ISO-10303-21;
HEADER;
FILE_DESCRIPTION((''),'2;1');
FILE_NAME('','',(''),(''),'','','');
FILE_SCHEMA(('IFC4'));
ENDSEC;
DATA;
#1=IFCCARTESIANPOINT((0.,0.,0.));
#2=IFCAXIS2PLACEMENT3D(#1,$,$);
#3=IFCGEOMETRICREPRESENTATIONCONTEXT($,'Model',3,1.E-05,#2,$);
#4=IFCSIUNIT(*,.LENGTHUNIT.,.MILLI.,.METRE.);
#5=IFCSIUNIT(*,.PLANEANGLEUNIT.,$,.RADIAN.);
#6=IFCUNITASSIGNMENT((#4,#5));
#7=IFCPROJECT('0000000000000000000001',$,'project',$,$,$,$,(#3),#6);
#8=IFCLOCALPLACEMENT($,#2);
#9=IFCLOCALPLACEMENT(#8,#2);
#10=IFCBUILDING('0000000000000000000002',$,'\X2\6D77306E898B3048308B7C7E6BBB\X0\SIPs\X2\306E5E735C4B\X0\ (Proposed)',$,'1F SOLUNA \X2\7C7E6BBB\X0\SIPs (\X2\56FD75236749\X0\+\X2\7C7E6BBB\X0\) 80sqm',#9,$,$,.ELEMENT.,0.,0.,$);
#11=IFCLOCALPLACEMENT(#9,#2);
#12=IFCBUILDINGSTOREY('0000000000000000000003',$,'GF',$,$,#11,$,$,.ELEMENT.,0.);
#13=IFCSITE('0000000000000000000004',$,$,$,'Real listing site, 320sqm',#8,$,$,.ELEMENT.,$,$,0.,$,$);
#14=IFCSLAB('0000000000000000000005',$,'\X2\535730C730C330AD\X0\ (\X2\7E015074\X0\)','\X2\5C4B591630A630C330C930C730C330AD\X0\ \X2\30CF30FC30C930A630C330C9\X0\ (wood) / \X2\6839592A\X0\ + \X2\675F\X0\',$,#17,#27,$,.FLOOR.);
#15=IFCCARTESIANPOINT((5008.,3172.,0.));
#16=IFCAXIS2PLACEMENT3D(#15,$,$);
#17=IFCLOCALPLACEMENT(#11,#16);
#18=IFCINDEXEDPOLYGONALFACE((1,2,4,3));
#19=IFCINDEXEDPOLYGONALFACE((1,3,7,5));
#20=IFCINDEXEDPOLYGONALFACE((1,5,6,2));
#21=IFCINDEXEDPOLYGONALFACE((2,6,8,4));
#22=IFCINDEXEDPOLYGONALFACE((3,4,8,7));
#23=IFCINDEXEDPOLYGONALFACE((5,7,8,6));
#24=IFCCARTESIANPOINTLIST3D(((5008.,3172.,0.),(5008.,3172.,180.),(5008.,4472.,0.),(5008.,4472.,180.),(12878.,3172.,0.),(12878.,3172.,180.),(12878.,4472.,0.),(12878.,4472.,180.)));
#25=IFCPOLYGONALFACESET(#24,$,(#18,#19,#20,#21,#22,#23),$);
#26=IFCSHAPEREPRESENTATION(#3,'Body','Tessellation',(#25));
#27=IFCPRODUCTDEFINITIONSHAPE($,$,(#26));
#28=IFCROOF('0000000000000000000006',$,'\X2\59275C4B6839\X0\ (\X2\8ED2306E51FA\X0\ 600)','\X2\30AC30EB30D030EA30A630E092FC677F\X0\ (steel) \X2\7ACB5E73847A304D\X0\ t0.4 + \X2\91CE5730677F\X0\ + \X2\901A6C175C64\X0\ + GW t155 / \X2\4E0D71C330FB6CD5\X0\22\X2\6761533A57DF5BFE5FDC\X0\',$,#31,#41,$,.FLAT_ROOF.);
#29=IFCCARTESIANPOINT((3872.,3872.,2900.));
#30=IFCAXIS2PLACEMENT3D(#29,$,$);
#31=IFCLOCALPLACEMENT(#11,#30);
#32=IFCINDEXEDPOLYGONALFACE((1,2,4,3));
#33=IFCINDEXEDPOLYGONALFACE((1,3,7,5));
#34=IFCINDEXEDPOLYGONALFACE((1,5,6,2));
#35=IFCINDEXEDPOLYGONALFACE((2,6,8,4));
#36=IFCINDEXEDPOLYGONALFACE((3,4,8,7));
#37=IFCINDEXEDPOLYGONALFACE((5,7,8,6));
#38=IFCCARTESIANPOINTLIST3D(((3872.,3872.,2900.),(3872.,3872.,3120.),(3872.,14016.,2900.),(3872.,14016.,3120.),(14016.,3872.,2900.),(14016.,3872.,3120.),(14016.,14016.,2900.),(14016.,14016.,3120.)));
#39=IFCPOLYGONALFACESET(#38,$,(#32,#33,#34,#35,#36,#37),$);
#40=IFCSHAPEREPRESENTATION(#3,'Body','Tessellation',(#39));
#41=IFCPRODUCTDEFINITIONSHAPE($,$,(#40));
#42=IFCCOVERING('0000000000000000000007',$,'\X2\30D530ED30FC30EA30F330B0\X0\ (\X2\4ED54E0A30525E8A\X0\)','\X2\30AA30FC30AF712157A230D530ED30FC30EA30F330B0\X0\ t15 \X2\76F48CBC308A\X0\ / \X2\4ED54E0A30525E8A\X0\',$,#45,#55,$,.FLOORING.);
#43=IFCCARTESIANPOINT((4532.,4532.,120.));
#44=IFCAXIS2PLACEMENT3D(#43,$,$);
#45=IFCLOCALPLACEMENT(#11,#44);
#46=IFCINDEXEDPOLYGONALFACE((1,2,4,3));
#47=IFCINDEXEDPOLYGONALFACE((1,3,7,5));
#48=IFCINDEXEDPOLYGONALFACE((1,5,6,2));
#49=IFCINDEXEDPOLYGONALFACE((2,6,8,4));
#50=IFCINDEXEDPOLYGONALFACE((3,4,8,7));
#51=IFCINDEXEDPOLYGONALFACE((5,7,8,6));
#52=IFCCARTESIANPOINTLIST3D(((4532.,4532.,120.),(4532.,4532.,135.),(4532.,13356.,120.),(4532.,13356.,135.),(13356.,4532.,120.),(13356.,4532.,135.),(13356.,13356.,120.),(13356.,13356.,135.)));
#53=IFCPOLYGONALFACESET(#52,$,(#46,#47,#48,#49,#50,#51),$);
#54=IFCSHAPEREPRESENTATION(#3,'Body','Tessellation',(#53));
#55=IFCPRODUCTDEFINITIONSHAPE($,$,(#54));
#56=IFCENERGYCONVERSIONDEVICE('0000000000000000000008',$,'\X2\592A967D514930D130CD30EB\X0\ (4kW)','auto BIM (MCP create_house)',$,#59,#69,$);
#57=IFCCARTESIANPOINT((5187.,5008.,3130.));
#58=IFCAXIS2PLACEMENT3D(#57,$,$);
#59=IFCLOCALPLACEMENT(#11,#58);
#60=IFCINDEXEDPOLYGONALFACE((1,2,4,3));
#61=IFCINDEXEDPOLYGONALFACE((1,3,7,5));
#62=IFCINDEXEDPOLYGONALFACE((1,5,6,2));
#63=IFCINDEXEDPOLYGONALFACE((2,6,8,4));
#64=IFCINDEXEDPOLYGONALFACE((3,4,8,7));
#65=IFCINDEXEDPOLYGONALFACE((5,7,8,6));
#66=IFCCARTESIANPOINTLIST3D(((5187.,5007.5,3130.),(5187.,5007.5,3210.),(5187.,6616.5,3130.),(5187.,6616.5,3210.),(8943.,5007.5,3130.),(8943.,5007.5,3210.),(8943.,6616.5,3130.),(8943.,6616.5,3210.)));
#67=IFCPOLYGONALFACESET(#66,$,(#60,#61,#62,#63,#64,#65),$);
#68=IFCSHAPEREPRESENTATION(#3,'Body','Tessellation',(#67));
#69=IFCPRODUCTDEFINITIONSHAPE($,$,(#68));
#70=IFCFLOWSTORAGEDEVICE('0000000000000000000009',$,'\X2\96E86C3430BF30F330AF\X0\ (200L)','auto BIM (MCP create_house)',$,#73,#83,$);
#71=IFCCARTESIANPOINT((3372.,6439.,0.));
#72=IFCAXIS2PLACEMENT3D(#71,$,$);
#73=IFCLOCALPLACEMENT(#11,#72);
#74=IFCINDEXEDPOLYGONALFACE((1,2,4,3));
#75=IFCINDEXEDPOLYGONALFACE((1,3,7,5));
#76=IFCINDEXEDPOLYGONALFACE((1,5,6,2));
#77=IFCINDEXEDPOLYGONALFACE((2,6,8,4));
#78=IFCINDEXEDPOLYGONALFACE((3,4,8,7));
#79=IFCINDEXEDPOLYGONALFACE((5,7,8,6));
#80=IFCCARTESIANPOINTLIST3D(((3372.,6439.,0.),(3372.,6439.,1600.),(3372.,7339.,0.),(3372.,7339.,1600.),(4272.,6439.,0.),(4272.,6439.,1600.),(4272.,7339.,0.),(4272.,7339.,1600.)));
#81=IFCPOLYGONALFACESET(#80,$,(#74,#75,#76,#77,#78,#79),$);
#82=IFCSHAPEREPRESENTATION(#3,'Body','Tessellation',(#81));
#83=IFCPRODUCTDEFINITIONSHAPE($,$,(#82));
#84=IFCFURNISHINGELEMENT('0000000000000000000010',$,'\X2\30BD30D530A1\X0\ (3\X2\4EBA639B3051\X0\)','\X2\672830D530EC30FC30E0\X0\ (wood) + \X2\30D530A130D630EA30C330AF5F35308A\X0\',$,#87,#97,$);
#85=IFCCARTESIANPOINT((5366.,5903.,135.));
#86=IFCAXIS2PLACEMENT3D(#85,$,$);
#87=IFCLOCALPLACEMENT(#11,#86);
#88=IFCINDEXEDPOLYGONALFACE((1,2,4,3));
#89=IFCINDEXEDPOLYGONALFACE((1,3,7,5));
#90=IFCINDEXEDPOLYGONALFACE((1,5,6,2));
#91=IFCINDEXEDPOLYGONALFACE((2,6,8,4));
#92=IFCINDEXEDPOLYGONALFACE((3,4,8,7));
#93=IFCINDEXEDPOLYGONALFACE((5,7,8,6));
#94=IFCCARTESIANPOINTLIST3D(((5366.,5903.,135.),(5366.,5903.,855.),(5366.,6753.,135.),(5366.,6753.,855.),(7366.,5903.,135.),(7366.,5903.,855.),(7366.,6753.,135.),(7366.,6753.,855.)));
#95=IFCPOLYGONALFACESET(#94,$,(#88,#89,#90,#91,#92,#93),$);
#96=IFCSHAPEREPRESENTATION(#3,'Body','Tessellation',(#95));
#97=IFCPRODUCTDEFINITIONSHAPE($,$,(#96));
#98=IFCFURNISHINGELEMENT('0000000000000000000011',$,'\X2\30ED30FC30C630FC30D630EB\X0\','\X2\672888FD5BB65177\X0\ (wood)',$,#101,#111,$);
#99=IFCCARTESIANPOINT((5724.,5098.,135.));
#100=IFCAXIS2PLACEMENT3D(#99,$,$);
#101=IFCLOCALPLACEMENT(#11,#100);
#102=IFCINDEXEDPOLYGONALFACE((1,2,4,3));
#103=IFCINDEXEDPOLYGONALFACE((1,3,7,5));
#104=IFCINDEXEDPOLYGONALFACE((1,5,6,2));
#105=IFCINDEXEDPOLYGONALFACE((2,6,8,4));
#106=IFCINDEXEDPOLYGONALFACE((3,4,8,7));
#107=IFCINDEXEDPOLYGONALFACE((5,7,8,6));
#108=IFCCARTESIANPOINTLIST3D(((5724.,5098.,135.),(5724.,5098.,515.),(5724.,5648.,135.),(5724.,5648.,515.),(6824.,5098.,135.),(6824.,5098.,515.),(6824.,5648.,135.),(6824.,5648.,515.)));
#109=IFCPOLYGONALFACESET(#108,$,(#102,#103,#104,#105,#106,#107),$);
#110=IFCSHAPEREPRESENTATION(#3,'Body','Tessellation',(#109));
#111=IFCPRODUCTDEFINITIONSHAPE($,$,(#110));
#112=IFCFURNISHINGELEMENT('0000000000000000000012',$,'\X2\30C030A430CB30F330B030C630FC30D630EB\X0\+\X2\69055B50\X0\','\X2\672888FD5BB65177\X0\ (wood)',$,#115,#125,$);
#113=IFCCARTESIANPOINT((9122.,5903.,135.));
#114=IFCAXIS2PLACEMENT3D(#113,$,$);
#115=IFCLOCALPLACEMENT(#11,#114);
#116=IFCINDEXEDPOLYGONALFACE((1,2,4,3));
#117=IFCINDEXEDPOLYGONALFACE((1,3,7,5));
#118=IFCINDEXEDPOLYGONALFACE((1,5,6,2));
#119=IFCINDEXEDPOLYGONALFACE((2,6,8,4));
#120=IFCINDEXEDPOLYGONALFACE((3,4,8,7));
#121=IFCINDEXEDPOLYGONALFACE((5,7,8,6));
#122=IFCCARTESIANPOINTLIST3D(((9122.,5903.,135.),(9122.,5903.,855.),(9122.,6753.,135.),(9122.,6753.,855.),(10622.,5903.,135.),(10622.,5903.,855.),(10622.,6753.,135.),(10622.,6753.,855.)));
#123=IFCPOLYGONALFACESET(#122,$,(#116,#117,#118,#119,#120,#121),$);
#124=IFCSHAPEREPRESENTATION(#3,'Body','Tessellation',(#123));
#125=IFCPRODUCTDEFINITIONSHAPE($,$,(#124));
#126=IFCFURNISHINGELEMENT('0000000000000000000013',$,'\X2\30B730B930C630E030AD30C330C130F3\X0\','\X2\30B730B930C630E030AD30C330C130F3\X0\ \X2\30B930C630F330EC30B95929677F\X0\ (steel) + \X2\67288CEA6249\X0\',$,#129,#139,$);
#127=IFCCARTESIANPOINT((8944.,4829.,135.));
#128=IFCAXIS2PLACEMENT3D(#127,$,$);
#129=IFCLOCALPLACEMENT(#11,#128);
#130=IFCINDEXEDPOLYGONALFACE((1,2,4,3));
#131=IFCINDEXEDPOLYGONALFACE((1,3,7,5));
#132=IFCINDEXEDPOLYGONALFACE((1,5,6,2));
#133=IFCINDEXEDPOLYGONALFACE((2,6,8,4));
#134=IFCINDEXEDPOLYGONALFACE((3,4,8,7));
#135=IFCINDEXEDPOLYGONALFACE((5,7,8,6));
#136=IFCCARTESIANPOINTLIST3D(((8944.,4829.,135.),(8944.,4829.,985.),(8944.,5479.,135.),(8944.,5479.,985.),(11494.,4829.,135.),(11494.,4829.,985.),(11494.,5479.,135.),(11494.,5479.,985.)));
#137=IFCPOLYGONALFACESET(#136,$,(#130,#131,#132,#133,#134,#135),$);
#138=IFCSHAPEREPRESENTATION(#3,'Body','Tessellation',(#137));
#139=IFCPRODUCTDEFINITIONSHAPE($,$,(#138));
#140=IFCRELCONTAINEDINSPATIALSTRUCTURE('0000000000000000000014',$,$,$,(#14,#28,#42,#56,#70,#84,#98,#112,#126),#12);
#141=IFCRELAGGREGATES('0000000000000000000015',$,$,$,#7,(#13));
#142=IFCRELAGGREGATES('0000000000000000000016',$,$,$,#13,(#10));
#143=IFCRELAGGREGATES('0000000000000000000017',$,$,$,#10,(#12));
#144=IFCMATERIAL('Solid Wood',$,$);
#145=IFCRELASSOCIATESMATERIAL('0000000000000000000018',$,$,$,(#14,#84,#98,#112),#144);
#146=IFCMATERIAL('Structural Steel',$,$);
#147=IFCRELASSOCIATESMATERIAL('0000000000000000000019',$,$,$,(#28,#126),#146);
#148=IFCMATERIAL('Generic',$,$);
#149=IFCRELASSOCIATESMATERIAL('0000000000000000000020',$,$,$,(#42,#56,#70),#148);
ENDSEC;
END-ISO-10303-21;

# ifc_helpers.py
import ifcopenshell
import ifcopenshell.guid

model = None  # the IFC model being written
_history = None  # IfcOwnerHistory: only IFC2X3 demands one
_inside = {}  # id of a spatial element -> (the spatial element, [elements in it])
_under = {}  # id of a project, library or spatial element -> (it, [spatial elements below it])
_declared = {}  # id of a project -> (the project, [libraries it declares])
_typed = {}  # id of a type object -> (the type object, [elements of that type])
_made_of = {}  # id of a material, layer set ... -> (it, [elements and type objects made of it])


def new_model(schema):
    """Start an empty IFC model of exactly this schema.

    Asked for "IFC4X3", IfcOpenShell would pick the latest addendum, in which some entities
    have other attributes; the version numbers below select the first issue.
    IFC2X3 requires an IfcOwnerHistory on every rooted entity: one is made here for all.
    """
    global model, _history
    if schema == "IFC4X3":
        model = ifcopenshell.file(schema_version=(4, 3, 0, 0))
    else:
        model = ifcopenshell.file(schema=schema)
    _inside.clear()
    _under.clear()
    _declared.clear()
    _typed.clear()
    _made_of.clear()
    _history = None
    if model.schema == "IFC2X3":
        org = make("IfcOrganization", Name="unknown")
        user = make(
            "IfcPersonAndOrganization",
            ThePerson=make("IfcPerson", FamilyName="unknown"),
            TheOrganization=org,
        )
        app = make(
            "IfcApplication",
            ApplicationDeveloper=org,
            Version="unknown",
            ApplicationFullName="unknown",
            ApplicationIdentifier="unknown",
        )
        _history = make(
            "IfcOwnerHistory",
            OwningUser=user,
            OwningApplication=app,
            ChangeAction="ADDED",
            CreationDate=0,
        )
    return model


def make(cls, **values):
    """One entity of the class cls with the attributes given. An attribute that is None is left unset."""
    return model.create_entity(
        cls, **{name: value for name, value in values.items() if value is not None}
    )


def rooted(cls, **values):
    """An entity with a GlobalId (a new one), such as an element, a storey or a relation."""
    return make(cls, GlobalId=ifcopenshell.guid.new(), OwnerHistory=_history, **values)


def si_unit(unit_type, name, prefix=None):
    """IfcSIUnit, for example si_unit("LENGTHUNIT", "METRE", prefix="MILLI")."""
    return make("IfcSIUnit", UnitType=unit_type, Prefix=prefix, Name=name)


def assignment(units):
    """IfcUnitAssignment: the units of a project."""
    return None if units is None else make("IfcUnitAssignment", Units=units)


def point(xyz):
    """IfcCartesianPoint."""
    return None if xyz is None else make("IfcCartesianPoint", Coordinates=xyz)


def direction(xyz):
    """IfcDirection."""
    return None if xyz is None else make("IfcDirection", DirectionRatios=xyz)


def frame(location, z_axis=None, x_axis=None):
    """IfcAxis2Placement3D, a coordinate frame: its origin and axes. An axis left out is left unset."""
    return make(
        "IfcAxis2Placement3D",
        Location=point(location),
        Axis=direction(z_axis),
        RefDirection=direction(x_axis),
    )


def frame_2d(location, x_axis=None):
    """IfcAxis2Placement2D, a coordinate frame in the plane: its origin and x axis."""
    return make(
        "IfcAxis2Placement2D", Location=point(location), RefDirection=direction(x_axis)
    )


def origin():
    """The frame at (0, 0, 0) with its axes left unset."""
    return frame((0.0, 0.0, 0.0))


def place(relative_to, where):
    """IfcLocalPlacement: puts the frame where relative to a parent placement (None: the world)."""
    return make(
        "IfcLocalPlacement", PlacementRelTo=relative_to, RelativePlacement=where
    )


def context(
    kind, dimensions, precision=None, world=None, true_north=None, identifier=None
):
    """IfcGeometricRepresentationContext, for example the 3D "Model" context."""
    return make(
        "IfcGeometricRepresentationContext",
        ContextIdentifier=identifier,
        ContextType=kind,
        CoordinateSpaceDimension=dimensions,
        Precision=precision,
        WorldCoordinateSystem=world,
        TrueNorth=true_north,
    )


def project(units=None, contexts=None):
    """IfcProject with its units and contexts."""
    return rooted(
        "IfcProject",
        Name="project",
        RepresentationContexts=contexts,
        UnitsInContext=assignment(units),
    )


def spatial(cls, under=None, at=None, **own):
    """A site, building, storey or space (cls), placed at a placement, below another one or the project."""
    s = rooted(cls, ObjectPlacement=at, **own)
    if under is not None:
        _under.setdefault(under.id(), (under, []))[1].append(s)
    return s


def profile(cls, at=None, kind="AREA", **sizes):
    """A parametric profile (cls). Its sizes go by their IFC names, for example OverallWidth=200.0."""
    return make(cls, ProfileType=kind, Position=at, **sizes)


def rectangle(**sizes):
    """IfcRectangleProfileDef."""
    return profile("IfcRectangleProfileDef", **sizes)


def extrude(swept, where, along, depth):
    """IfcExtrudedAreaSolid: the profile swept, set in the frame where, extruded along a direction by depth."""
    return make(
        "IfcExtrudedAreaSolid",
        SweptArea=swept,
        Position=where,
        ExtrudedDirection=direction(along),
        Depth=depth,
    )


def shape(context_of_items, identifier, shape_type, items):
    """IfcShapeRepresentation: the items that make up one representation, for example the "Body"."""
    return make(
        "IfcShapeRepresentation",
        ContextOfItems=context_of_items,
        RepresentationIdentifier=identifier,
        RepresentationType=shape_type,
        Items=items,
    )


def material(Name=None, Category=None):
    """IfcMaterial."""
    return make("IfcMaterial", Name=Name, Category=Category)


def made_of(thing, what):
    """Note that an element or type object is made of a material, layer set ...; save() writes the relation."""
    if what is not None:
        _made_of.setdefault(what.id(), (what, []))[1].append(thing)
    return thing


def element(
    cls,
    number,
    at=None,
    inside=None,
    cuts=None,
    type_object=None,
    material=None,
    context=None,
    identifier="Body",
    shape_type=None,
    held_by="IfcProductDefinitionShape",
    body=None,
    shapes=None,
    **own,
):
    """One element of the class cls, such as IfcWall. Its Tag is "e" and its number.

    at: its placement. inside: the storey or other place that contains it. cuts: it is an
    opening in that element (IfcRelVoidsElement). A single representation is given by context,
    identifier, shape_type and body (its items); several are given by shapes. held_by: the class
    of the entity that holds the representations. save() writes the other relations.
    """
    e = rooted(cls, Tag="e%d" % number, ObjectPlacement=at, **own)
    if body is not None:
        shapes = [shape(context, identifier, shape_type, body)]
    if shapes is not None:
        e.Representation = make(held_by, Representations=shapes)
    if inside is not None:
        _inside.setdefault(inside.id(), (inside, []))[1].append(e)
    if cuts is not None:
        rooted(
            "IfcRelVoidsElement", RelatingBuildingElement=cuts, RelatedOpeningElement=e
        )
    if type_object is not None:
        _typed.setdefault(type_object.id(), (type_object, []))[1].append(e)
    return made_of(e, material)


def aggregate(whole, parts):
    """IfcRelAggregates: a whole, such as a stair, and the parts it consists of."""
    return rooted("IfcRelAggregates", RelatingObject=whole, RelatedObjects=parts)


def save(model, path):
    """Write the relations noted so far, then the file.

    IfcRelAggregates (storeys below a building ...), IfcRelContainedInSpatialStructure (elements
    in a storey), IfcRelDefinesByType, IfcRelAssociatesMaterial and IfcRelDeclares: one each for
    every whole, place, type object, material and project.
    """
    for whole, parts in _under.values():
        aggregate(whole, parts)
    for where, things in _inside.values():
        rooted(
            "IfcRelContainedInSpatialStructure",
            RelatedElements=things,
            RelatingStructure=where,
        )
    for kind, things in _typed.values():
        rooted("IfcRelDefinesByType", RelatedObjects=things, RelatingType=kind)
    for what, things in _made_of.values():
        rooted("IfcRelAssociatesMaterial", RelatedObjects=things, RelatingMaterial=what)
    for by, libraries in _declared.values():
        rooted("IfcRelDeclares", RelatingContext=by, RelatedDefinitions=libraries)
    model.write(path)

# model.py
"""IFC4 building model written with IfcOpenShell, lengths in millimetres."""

from ifc_helpers import new_model, si_unit, frame, frame_2d, origin, place, context, project, spatial, rectangle, extrude, material, element, save


model = new_model("IFC4")

# Units and contexts
model_context = context("Model", 3, precision=1e-05, world=origin())
ifc_project = project(units=[si_unit("LENGTHUNIT", "METRE", prefix="MILLI"), si_unit("PLANEANGLEUNIT", "RADIAN")], contexts=[model_context])

# Site, building, storey
site_placement = place(None, origin())
site = spatial("IfcSite", under=ifc_project, at=site_placement, ObjectType="Real listing site, 320sqm", CompositionType="ELEMENT", RefElevation=0.0)
building_placement = place(site_placement, origin())
building = spatial("IfcBuilding", under=site, at=building_placement, Name="海の見える籾殻SIPsの平屋 (Proposed)", ObjectType="1F SOLUNA 籾殻SIPs (国産杉+籾殻) 80sqm", CompositionType="ELEMENT", ElevationOfRefHeight=0.0, ElevationOfTerrain=0.0)
storey_placement = place(building_placement, origin())
storey = spatial("IfcBuildingStorey", under=building, at=storey_placement, Name="GF", CompositionType="ELEMENT", Elevation=0.0)

# Slab
ifc_material_1 = material(Name="Solid Wood")
slab_1_placement = place(storey_placement, frame((5008.0, 3172.0, 0.0)))
element("IfcSlab", 1, at=slab_1_placement, inside=storey, material=ifc_material_1, Name="南デッキ (縁側)", Description="屋外ウッドデッキ ハードウッド (wood) / 根太 + 束", PredefinedType="FLOOR", context=model_context, shape_type="SweptSolid", body=[
    extrude(rectangle(XDim=7870.0, YDim=1300.0, at=frame_2d((3935.0, 650.0))), frame((5008.0, 3172.0, 0.0)), (0.0, 0.0, 1.0), 180.0),
])

# Roof
ifc_material_2 = material(Name="Structural Steel")
roof_placement = place(storey_placement, frame((3872.0, 3872.0, 2900.0)))
element("IfcRoof", 2, at=roof_placement, inside=storey, material=ifc_material_2, Name="大屋根 (軒の出 600)", Description="ガルバリウム鋼板 (steel) 立平葺き t0.4 + 野地板 + 通気層 + GW t155 / 不燃・法22条区域対応", PredefinedType="FLAT_ROOF", context=model_context, shape_type="SweptSolid", body=[
    extrude(rectangle(XDim=10144.0, YDim=10144.0, at=frame_2d((5072.0, 5072.0))), frame((3872.0, 3872.0, 2900.0)), (0.0, 0.0, 1.0), 220.0),
])

# Covering
ifc_material_3 = material(Name="Generic")
covering_placement = place(storey_placement, frame((4532.0, 4532.0, 120.0)))
element("IfcCovering", 3, at=covering_placement, inside=storey, material=ifc_material_3, Name="フローリング (仕上げ床)", Description="オーク無垢フローリング t15 直貼り / 仕上げ床", PredefinedType="FLOORING", context=model_context, shape_type="SweptSolid", body=[
    extrude(rectangle(XDim=8824.0, YDim=8824.0, at=frame_2d((4412.0, 4412.0))), frame((4532.0, 4532.0, 120.0)), (0.0, 0.0, 1.0), 15.0),
])

# Energy conversion device
energy_conversion_device_placement = place(storey_placement, frame((5187.0, 5008.0, 3130.0)))
element("IfcEnergyConversionDevice", 4, at=energy_conversion_device_placement, inside=storey, material=ifc_material_3, Name="太陽光パネル (4kW)", Description="auto BIM (MCP create_house)", context=model_context, shape_type="SweptSolid", body=[
    extrude(rectangle(XDim=3756.0, YDim=1609.0, at=frame_2d((1878.0, 804.0))), frame((5187.0, 5008.0, 3130.0)), (0.0, 0.0, 1.0), 80.0),
])

# Flow storage device
flow_storage_device_placement = place(storey_placement, frame((3372.0, 6439.0, 0.0)))
element("IfcFlowStorageDevice", 5, at=flow_storage_device_placement, inside=storey, material=ifc_material_3, Name="雨水タンク (200L)", Description="auto BIM (MCP create_house)", context=model_context, shape_type="SweptSolid", body=[
    extrude(rectangle(XDim=900.0, YDim=900.0, at=frame_2d((450.0, 450.0))), frame((3372.0, 6439.0, 0.0)), (0.0, 0.0, 1.0), 1600.0),
])

# Furnishing elements
furnishing_1_placement = place(storey_placement, frame((5366.0, 5903.0, 135.0)))
element("IfcFurnishingElement", 6, at=furnishing_1_placement, inside=storey, material=ifc_material_1, Name="ソファ (3人掛け)", Description="木フレーム (wood) + ファブリック張り", context=model_context, shape_type="SweptSolid", body=[
    extrude(rectangle(XDim=2000.0, YDim=850.0, at=frame_2d((1000.0, 425.0))), frame((5366.0, 5903.0, 135.0)), (0.0, 0.0, 1.0), 720.0),
])
furnishing_2_placement = place(storey_placement, frame((5724.0, 5098.0, 135.0)))
element("IfcFurnishingElement", 7, at=furnishing_2_placement, inside=storey, material=ifc_material_1, Name="ローテーブル", Description="木製家具 (wood)", context=model_context, shape_type="SweptSolid", body=[
    extrude(rectangle(XDim=1100.0, YDim=550.0, at=frame_2d((550.0, 275.0))), frame((5724.0, 5098.0, 135.0)), (0.0, 0.0, 1.0), 380.0),
])
furnishing_3_placement = place(storey_placement, frame((9122.0, 5903.0, 135.0)))
element("IfcFurnishingElement", 8, at=furnishing_3_placement, inside=storey, material=ifc_material_1, Name="ダイニングテーブル+椅子", Description="木製家具 (wood)", context=model_context, shape_type="SweptSolid", body=[
    extrude(rectangle(XDim=1500.0, YDim=850.0, at=frame_2d((750.0, 425.0))), frame((9122.0, 5903.0, 135.0)), (0.0, 0.0, 1.0), 720.0),
])
furnishing_4_placement = place(storey_placement, frame((8944.0, 4829.0, 135.0)))
element("IfcFurnishingElement", 9, at=furnishing_4_placement, inside=storey, material=ifc_material_2, Name="システムキッチン", Description="システムキッチン ステンレス天板 (steel) + 木質扉", context=model_context, shape_type="SweptSolid", body=[
    extrude(rectangle(XDim=2550.0, YDim=650.0, at=frame_2d((1275.0, 325.0))), frame((8944.0, 4829.0, 135.0)), (0.0, 0.0, 1.0), 850.0),
])

save(model, "model.ifc")
